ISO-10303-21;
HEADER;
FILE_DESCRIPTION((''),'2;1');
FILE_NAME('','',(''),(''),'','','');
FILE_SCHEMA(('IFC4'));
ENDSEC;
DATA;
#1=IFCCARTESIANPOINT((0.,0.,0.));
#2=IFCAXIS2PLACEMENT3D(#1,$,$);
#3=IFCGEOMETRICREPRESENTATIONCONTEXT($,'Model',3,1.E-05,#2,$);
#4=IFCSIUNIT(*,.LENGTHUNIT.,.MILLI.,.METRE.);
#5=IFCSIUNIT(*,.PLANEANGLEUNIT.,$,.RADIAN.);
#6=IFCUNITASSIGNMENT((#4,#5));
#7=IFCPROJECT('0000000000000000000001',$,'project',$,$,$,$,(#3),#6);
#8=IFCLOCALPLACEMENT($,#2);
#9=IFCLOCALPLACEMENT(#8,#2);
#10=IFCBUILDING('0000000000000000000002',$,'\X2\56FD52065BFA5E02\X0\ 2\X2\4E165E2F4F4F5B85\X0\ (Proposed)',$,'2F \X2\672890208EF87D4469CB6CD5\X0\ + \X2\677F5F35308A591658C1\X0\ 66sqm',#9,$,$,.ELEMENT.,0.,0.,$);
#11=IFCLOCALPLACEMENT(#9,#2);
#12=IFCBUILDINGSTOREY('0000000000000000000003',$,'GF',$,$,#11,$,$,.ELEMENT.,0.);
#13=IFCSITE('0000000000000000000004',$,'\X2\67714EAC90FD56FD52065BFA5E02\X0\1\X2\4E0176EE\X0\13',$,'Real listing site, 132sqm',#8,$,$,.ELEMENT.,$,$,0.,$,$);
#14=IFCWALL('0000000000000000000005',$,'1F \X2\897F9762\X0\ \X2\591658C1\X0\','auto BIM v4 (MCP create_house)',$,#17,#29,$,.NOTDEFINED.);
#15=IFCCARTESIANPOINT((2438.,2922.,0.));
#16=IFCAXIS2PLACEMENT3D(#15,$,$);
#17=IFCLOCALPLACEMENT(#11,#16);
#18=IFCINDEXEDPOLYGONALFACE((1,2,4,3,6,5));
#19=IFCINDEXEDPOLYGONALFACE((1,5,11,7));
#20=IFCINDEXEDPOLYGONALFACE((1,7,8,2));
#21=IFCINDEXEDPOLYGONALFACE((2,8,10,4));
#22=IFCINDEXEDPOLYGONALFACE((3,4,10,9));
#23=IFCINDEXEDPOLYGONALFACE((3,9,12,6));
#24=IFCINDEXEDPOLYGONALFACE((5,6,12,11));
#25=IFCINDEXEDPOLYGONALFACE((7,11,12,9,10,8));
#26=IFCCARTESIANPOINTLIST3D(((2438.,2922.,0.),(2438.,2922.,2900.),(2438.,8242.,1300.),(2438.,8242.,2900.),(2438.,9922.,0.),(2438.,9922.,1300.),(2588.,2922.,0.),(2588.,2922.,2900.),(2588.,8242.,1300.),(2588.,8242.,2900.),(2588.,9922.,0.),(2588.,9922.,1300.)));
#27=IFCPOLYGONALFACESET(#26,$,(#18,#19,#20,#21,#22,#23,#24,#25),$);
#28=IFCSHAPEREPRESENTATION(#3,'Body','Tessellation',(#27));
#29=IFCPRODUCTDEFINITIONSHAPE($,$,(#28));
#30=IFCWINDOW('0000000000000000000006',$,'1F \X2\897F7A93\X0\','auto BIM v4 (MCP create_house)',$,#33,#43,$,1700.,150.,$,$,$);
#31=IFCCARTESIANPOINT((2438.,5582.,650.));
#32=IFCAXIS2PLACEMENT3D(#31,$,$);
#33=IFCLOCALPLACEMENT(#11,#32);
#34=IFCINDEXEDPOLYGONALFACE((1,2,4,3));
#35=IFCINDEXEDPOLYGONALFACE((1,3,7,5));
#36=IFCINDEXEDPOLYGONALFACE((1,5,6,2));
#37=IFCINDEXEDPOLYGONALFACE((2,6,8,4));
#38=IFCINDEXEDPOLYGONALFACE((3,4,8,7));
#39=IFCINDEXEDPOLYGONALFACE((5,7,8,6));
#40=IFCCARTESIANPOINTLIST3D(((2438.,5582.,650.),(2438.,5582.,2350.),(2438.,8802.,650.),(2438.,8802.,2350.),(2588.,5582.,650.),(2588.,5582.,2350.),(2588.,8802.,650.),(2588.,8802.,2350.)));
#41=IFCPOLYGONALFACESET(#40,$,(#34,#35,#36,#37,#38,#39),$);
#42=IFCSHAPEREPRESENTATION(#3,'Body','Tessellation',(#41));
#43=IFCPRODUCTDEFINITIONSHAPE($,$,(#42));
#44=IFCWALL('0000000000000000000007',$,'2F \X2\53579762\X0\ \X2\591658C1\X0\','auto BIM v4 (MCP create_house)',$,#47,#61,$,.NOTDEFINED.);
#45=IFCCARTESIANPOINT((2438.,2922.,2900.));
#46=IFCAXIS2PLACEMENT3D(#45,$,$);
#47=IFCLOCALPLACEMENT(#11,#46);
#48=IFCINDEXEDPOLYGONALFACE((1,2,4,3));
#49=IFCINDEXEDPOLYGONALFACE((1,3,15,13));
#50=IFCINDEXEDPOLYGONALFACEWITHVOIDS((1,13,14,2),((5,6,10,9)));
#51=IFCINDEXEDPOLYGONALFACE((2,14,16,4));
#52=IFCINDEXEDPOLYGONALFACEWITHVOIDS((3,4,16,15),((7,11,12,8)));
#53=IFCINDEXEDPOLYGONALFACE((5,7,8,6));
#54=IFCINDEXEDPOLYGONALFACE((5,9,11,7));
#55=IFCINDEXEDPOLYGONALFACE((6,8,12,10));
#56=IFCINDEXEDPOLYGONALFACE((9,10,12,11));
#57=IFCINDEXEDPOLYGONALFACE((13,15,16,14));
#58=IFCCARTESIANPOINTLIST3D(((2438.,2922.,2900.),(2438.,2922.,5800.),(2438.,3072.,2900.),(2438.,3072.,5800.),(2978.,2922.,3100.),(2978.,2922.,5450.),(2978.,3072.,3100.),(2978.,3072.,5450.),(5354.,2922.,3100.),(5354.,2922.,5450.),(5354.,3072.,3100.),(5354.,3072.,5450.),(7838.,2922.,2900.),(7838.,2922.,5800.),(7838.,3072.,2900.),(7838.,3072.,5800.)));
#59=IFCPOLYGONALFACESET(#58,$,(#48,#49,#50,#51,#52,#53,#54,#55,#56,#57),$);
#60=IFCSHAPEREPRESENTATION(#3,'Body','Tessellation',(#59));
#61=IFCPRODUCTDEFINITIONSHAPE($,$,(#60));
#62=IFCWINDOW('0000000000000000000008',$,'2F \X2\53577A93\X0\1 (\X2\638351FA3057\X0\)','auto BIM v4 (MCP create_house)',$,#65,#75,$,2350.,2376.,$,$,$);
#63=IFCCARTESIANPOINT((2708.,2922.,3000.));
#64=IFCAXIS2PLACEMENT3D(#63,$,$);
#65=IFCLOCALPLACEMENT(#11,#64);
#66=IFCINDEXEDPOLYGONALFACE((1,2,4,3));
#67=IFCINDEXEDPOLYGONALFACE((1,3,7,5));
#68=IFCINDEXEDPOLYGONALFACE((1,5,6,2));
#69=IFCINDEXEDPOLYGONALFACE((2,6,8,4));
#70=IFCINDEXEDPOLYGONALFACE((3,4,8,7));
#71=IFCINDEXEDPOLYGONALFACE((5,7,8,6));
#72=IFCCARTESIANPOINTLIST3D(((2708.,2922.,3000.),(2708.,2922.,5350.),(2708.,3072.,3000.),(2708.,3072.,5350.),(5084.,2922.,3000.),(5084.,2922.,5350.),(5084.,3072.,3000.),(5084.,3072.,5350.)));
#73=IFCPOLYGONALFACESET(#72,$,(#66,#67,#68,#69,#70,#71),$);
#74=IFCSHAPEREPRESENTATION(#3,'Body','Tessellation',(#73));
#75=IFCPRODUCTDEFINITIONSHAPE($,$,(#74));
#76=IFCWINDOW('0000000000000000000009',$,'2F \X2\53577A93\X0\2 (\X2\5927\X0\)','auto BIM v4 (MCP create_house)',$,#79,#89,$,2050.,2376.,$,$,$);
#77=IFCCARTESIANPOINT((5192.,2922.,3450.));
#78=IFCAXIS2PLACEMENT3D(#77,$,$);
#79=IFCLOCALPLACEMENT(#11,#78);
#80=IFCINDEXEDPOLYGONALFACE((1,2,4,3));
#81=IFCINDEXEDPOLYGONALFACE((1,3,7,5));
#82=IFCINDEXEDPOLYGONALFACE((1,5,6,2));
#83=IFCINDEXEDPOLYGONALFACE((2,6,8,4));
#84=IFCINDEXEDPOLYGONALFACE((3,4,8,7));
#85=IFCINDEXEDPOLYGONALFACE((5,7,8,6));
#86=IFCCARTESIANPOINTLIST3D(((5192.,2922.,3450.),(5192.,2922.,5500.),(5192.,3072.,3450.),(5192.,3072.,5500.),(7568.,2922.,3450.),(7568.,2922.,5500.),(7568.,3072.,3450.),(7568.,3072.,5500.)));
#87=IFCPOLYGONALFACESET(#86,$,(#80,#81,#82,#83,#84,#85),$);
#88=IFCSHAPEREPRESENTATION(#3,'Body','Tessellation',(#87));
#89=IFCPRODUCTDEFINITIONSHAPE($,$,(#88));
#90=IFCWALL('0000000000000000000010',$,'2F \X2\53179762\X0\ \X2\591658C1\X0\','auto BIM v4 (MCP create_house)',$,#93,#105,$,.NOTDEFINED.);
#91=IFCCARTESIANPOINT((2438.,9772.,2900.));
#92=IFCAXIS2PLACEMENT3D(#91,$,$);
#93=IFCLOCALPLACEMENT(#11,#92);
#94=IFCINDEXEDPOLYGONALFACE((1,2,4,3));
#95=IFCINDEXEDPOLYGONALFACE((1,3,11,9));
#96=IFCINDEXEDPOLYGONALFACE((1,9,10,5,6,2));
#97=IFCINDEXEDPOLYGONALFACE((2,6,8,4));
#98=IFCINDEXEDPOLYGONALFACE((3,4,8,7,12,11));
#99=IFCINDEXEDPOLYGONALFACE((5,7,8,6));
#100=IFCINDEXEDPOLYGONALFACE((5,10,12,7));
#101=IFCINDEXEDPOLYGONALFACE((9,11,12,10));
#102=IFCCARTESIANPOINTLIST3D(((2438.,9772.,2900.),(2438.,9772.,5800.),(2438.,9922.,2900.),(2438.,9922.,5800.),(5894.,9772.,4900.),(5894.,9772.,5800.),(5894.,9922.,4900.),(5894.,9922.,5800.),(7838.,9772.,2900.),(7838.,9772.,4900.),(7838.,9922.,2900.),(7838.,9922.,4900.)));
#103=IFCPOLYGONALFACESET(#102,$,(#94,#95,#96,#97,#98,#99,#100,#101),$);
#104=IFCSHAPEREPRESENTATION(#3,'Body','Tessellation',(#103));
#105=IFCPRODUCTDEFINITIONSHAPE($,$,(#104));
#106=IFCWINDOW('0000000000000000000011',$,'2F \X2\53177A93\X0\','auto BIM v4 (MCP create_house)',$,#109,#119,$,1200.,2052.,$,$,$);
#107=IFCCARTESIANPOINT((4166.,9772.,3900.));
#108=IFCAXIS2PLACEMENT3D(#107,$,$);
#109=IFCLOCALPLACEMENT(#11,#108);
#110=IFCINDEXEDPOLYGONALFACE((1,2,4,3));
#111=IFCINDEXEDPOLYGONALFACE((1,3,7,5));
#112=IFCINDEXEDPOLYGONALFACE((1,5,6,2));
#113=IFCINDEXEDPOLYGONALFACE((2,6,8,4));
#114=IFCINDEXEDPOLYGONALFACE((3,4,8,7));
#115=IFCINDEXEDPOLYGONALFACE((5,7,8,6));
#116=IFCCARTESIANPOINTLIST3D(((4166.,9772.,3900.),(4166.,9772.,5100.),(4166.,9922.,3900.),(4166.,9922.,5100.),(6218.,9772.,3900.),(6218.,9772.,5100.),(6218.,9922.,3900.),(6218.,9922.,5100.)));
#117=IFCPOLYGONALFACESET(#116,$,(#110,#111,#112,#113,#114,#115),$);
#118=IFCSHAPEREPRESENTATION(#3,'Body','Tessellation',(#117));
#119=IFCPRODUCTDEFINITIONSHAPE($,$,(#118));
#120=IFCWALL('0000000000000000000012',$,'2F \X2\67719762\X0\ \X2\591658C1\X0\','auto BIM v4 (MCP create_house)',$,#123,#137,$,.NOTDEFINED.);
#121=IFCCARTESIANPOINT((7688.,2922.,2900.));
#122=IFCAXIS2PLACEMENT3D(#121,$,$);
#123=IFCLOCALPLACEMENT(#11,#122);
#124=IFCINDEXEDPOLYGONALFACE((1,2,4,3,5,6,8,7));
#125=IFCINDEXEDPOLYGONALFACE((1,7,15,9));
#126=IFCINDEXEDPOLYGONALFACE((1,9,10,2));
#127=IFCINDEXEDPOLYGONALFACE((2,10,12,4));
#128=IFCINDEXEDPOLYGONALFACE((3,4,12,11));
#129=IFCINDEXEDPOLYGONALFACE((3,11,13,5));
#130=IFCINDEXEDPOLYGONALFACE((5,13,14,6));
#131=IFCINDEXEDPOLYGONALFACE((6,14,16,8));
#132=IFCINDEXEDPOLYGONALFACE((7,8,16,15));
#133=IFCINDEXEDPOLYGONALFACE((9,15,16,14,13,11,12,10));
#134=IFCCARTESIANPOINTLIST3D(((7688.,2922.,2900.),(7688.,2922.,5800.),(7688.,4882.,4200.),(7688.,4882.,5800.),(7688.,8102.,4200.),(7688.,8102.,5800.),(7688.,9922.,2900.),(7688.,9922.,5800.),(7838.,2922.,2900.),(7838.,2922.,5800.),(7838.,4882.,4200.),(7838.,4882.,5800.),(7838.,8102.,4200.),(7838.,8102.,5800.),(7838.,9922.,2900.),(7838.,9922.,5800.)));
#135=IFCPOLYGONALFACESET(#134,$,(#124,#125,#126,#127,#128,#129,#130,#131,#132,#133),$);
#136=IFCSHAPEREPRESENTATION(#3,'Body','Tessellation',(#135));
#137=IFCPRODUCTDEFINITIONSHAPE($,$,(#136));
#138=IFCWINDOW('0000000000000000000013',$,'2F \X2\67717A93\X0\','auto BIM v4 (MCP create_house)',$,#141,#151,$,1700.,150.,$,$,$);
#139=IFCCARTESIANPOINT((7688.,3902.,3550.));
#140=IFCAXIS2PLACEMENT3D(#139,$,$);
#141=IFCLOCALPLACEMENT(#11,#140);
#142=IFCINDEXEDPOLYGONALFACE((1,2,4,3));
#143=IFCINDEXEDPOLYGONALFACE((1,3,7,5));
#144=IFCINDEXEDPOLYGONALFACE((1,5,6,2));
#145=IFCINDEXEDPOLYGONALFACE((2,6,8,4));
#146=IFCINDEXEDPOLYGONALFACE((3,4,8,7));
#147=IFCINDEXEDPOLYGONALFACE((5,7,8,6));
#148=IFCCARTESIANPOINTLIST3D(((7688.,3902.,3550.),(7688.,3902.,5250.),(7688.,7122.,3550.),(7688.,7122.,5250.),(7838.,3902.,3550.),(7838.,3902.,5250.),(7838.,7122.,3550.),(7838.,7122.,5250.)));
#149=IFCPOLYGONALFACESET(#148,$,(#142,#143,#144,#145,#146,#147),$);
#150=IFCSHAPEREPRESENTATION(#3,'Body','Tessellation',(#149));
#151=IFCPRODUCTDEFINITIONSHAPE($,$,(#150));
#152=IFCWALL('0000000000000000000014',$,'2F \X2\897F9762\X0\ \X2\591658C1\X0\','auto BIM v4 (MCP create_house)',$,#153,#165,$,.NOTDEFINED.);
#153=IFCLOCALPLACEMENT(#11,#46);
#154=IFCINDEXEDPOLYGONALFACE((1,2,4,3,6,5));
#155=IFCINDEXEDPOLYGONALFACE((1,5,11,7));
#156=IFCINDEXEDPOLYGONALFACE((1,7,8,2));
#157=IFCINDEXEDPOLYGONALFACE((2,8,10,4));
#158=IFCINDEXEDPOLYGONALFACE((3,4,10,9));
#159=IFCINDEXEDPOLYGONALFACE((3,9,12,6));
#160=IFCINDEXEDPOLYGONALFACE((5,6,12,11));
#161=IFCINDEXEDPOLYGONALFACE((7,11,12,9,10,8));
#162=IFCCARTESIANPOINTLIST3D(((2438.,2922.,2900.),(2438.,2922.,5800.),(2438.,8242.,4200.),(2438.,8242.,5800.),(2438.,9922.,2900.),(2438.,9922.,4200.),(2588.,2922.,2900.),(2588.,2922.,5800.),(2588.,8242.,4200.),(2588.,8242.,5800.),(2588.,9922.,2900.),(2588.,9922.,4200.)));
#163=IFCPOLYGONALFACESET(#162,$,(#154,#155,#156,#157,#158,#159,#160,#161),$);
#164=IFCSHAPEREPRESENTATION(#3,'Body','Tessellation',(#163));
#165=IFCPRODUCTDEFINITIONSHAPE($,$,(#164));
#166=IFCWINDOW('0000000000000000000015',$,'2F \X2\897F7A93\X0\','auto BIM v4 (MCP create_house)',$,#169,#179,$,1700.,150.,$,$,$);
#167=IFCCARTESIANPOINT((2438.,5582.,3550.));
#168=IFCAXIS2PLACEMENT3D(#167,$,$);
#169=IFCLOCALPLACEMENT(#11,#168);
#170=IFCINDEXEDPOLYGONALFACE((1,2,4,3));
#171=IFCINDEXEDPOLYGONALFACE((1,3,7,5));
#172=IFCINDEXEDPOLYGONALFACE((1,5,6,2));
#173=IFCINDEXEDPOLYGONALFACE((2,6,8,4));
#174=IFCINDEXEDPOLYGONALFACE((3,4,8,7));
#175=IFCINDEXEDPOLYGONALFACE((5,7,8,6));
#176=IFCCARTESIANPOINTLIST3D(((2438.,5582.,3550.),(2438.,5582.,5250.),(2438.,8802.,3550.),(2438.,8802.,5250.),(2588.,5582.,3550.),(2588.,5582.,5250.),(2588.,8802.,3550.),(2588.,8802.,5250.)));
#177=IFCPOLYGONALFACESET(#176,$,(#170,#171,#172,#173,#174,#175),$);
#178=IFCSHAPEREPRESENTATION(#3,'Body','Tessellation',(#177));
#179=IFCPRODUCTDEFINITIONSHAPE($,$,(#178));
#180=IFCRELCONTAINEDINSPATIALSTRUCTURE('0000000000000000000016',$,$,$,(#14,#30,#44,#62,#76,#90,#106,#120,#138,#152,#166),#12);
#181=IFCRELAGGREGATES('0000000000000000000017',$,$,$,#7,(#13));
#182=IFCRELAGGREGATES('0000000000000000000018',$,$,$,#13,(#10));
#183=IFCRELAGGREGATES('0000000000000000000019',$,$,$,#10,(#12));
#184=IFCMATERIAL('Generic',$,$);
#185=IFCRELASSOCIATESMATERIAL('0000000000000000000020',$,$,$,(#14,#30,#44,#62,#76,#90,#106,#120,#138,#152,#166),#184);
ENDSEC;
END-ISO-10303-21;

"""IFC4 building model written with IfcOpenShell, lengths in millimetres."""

from ifc_helpers import new_model, si_unit, frame, frame_2d, origin, place, context, project, spatial, rectangle, extrude, material, element, fill, save


model = new_model("IFC4")

# Units and contexts
model_context = context("Model", 3, precision=1e-05, world=origin())
ifc_project = project(units=[si_unit("LENGTHUNIT", "METRE", prefix="MILLI"), si_unit("PLANEANGLEUNIT", "RADIAN")], contexts=[model_context])

# Site, building, storey
site_placement = place(None, origin())
site = spatial("IfcSite", under=ifc_project, at=site_placement, Name="東京都国分寺市1丁目13", ObjectType="Real listing site, 132sqm", CompositionType="ELEMENT", RefElevation=0.0)
building_placement = place(site_placement, origin())
building = spatial("IfcBuilding", under=site, at=building_placement, Name="国分寺市 2世帯住宅 (Proposed)", ObjectType="2F 木造軸組構法 + 板張り外壁 66sqm", CompositionType="ELEMENT", ElevationOfRefHeight=0.0, ElevationOfTerrain=0.0)
storey_placement = place(building_placement, origin())
storey = spatial("IfcBuildingStorey", under=building, at=storey_placement, Name="GF", CompositionType="ELEMENT", Elevation=0.0)

# Shared definitions
ifc_material = material(Name="Generic")

# Wall, opening, window
wall_1_placement = place(storey_placement, frame((2438.0, 2922.0, 0.0)))
wall_1 = element("IfcWall", 1, at=wall_1_placement, inside=storey, material=ifc_material, Name="1F 西面 外壁", Description="auto BIM v4 (MCP create_house)", PredefinedType="NOTDEFINED", context=model_context, shape_type="SweptSolid", body=[
    extrude(rectangle(XDim=150.0, YDim=7000.0, at=frame_2d((75.0, 3500.0))), frame((2438.0, 2922.0, 0.0)), (0.0, 0.0, 1.0), 2900.0),
])
opening_1_placement = place(storey_placement, frame((2438.0, 5582.0, 650.0)))
opening_1 = element("IfcOpeningElement", 2, at=opening_1_placement, cuts=wall_1, PredefinedType="NOTDEFINED", context=model_context, shape_type="SweptSolid", body=[
    extrude(rectangle(XDim=150.0, YDim=3220.0, at=frame_2d((75.0, 1610.0))), frame((2438.0, 5582.0, 650.0)), (0.0, 0.0, 1.0), 1700.0),
])
window_1_placement = place(storey_placement, frame((2438.0, 5582.0, 650.0)))
window_1 = element("IfcWindow", 3, at=window_1_placement, inside=storey, material=ifc_material, Name="1F 西窓", Description="auto BIM v4 (MCP create_house)", OverallHeight=1700.0, OverallWidth=150.0, context=model_context, shape_type="SweptSolid", body=[
    extrude(rectangle(XDim=150.0, YDim=3220.0, at=frame_2d((75.0, 1610.0))), frame((2438.0, 5582.0, 650.0)), (0.0, 0.0, 1.0), 1700.0),
])
fill(opening_1, window_1)

# Wall, openings, windows
wall_2_placement = place(storey_placement, frame((2438.0, 2922.0, 2900.0)))
wall_2 = element("IfcWall", 4, at=wall_2_placement, inside=storey, material=ifc_material, Name="2F 南面 外壁", Description="auto BIM v4 (MCP create_house)", PredefinedType="NOTDEFINED", context=model_context, shape_type="SweptSolid", body=[
    extrude(rectangle(XDim=5400.0, YDim=150.0, at=frame_2d((2700.0, 75.0))), frame((2438.0, 2922.0, 2900.0)), (0.0, 0.0, 1.0), 2900.0),
])
opening_2_placement = place(storey_placement, frame((2708.0, 2922.0, 3000.0)))
opening_2 = element("IfcOpeningElement", 5, at=opening_2_placement, cuts=wall_2, PredefinedType="NOTDEFINED", context=model_context, shape_type="SweptSolid", body=[
    extrude(rectangle(XDim=2376.0, YDim=150.0, at=frame_2d((1188.0, 75.0))), frame((2708.0, 2922.0, 3000.0)), (0.0, 0.0, 1.0), 2350.0),
])
opening_3_placement = place(storey_placement, frame((5192.0, 2922.0, 3450.0)))
opening_3 = element("IfcOpeningElement", 6, at=opening_3_placement, cuts=wall_2, PredefinedType="NOTDEFINED", context=model_context, shape_type="SweptSolid", body=[
    extrude(rectangle(XDim=2376.0, YDim=150.0, at=frame_2d((1188.0, 75.0))), frame((5192.0, 2922.0, 3450.0)), (0.0, 0.0, 1.0), 2050.0),
])
window_2_placement = place(storey_placement, frame((2708.0, 2922.0, 3000.0)))
window_2 = element("IfcWindow", 7, at=window_2_placement, inside=storey, material=ifc_material, Name="2F 南窓1 (掃出し)", Description="auto BIM v4 (MCP create_house)", OverallHeight=2350.0, OverallWidth=2376.0, context=model_context, shape_type="SweptSolid", body=[
    extrude(rectangle(XDim=2376.0, YDim=150.0, at=frame_2d((1188.0, 75.0))), frame((2708.0, 2922.0, 3000.0)), (0.0, 0.0, 1.0), 2350.0),
])
fill(opening_2, window_2)
window_3_placement = place(storey_placement, frame((5192.0, 2922.0, 3450.0)))
window_3 = element("IfcWindow", 8, at=window_3_placement, inside=storey, material=ifc_material, Name="2F 南窓2 (大)", Description="auto BIM v4 (MCP create_house)", OverallHeight=2050.0, OverallWidth=2376.0, context=model_context, shape_type="SweptSolid", body=[
    extrude(rectangle(XDim=2376.0, YDim=150.0, at=frame_2d((1188.0, 75.0))), frame((5192.0, 2922.0, 3450.0)), (0.0, 0.0, 1.0), 2050.0),
])
fill(opening_3, window_3)

# Walls, openings, windows
wall_3_placement = place(storey_placement, frame((2438.0, 9772.0, 2900.0)))
wall_3 = element("IfcWall", 9, at=wall_3_placement, inside=storey, material=ifc_material, Name="2F 北面 外壁", Description="auto BIM v4 (MCP create_house)", PredefinedType="NOTDEFINED", context=model_context, shape_type="SweptSolid", body=[
    extrude(rectangle(XDim=5400.0, YDim=150.0, at=frame_2d((2700.0, 75.0))), frame((2438.0, 9772.0, 2900.0)), (0.0, 0.0, 1.0), 2900.0),
])
opening_4_placement = place(storey_placement, frame((4166.0, 9772.0, 3900.0)))
opening_4 = element("IfcOpeningElement", 10, at=opening_4_placement, cuts=wall_3, PredefinedType="NOTDEFINED", context=model_context, shape_type="SweptSolid", body=[
    extrude(rectangle(XDim=2052.0, YDim=150.0, at=frame_2d((1026.0, 75.0))), frame((4166.0, 9772.0, 3900.0)), (0.0, 0.0, 1.0), 1200.0),
])
window_4_placement = place(storey_placement, frame((4166.0, 9772.0, 3900.0)))
window_4 = element("IfcWindow", 11, at=window_4_placement, inside=storey, material=ifc_material, Name="2F 北窓", Description="auto BIM v4 (MCP create_house)", OverallHeight=1200.0, OverallWidth=2052.0, context=model_context, shape_type="SweptSolid", body=[
    extrude(rectangle(XDim=2052.0, YDim=150.0, at=frame_2d((1026.0, 75.0))), frame((4166.0, 9772.0, 3900.0)), (0.0, 0.0, 1.0), 1200.0),
])
fill(opening_4, window_4)
wall_4_placement = place(storey_placement, frame((7688.0, 2922.0, 2900.0)))
wall_4 = element("IfcWall", 12, at=wall_4_placement, inside=storey, material=ifc_material, Name="2F 東面 外壁", Description="auto BIM v4 (MCP create_house)", PredefinedType="NOTDEFINED", context=model_context, shape_type="SweptSolid", body=[
    extrude(rectangle(XDim=150.0, YDim=7000.0, at=frame_2d((75.0, 3500.0))), frame((7688.0, 2922.0, 2900.0)), (0.0, 0.0, 1.0), 2900.0),
])
opening_5_placement = place(storey_placement, frame((7688.0, 3902.0, 3550.0)))
opening_5 = element("IfcOpeningElement", 13, at=opening_5_placement, cuts=wall_4, PredefinedType="NOTDEFINED", context=model_context, shape_type="SweptSolid", body=[
    extrude(rectangle(XDim=150.0, YDim=3220.0, at=frame_2d((75.0, 1610.0))), frame((7688.0, 3902.0, 3550.0)), (0.0, 0.0, 1.0), 1700.0),
])
window_5_placement = place(storey_placement, frame((7688.0, 3902.0, 3550.0)))
window_5 = element("IfcWindow", 14, at=window_5_placement, inside=storey, material=ifc_material, Name="2F 東窓", Description="auto BIM v4 (MCP create_house)", OverallHeight=1700.0, OverallWidth=150.0, context=model_context, shape_type="SweptSolid", body=[
    extrude(rectangle(XDim=150.0, YDim=3220.0, at=frame_2d((75.0, 1610.0))), frame((7688.0, 3902.0, 3550.0)), (0.0, 0.0, 1.0), 1700.0),
])
fill(opening_5, window_5)
wall_5_placement = place(storey_placement, frame((2438.0, 2922.0, 2900.0)))
wall_5 = element("IfcWall", 15, at=wall_5_placement, inside=storey, material=ifc_material, Name="2F 西面 外壁", Description="auto BIM v4 (MCP create_house)", PredefinedType="NOTDEFINED", context=model_context, shape_type="SweptSolid", body=[
    extrude(rectangle(XDim=150.0, YDim=7000.0, at=frame_2d((75.0, 3500.0))), frame((2438.0, 2922.0, 2900.0)), (0.0, 0.0, 1.0), 2900.0),
])
opening_6_placement = place(storey_placement, frame((2438.0, 5582.0, 3550.0)))
opening_6 = element("IfcOpeningElement", 16, at=opening_6_placement, cuts=wall_5, PredefinedType="NOTDEFINED", context=model_context, shape_type="SweptSolid", body=[
    extrude(rectangle(XDim=150.0, YDim=3220.0, at=frame_2d((75.0, 1610.0))), frame((2438.0, 5582.0, 3550.0)), (0.0, 0.0, 1.0), 1700.0),
])
window_6_placement = place(storey_placement, frame((2438.0, 5582.0, 3550.0)))
window_6 = element("IfcWindow", 17, at=window_6_placement, inside=storey, material=ifc_material, Name="2F 西窓", Description="auto BIM v4 (MCP create_house)", OverallHeight=1700.0, OverallWidth=150.0, context=model_context, shape_type="SweptSolid", body=[
    extrude(rectangle(XDim=150.0, YDim=3220.0, at=frame_2d((75.0, 1610.0))), frame((2438.0, 5582.0, 3550.0)), (0.0, 0.0, 1.0), 1700.0),
])
fill(opening_6, window_6)

save(model, "model.ifc")
